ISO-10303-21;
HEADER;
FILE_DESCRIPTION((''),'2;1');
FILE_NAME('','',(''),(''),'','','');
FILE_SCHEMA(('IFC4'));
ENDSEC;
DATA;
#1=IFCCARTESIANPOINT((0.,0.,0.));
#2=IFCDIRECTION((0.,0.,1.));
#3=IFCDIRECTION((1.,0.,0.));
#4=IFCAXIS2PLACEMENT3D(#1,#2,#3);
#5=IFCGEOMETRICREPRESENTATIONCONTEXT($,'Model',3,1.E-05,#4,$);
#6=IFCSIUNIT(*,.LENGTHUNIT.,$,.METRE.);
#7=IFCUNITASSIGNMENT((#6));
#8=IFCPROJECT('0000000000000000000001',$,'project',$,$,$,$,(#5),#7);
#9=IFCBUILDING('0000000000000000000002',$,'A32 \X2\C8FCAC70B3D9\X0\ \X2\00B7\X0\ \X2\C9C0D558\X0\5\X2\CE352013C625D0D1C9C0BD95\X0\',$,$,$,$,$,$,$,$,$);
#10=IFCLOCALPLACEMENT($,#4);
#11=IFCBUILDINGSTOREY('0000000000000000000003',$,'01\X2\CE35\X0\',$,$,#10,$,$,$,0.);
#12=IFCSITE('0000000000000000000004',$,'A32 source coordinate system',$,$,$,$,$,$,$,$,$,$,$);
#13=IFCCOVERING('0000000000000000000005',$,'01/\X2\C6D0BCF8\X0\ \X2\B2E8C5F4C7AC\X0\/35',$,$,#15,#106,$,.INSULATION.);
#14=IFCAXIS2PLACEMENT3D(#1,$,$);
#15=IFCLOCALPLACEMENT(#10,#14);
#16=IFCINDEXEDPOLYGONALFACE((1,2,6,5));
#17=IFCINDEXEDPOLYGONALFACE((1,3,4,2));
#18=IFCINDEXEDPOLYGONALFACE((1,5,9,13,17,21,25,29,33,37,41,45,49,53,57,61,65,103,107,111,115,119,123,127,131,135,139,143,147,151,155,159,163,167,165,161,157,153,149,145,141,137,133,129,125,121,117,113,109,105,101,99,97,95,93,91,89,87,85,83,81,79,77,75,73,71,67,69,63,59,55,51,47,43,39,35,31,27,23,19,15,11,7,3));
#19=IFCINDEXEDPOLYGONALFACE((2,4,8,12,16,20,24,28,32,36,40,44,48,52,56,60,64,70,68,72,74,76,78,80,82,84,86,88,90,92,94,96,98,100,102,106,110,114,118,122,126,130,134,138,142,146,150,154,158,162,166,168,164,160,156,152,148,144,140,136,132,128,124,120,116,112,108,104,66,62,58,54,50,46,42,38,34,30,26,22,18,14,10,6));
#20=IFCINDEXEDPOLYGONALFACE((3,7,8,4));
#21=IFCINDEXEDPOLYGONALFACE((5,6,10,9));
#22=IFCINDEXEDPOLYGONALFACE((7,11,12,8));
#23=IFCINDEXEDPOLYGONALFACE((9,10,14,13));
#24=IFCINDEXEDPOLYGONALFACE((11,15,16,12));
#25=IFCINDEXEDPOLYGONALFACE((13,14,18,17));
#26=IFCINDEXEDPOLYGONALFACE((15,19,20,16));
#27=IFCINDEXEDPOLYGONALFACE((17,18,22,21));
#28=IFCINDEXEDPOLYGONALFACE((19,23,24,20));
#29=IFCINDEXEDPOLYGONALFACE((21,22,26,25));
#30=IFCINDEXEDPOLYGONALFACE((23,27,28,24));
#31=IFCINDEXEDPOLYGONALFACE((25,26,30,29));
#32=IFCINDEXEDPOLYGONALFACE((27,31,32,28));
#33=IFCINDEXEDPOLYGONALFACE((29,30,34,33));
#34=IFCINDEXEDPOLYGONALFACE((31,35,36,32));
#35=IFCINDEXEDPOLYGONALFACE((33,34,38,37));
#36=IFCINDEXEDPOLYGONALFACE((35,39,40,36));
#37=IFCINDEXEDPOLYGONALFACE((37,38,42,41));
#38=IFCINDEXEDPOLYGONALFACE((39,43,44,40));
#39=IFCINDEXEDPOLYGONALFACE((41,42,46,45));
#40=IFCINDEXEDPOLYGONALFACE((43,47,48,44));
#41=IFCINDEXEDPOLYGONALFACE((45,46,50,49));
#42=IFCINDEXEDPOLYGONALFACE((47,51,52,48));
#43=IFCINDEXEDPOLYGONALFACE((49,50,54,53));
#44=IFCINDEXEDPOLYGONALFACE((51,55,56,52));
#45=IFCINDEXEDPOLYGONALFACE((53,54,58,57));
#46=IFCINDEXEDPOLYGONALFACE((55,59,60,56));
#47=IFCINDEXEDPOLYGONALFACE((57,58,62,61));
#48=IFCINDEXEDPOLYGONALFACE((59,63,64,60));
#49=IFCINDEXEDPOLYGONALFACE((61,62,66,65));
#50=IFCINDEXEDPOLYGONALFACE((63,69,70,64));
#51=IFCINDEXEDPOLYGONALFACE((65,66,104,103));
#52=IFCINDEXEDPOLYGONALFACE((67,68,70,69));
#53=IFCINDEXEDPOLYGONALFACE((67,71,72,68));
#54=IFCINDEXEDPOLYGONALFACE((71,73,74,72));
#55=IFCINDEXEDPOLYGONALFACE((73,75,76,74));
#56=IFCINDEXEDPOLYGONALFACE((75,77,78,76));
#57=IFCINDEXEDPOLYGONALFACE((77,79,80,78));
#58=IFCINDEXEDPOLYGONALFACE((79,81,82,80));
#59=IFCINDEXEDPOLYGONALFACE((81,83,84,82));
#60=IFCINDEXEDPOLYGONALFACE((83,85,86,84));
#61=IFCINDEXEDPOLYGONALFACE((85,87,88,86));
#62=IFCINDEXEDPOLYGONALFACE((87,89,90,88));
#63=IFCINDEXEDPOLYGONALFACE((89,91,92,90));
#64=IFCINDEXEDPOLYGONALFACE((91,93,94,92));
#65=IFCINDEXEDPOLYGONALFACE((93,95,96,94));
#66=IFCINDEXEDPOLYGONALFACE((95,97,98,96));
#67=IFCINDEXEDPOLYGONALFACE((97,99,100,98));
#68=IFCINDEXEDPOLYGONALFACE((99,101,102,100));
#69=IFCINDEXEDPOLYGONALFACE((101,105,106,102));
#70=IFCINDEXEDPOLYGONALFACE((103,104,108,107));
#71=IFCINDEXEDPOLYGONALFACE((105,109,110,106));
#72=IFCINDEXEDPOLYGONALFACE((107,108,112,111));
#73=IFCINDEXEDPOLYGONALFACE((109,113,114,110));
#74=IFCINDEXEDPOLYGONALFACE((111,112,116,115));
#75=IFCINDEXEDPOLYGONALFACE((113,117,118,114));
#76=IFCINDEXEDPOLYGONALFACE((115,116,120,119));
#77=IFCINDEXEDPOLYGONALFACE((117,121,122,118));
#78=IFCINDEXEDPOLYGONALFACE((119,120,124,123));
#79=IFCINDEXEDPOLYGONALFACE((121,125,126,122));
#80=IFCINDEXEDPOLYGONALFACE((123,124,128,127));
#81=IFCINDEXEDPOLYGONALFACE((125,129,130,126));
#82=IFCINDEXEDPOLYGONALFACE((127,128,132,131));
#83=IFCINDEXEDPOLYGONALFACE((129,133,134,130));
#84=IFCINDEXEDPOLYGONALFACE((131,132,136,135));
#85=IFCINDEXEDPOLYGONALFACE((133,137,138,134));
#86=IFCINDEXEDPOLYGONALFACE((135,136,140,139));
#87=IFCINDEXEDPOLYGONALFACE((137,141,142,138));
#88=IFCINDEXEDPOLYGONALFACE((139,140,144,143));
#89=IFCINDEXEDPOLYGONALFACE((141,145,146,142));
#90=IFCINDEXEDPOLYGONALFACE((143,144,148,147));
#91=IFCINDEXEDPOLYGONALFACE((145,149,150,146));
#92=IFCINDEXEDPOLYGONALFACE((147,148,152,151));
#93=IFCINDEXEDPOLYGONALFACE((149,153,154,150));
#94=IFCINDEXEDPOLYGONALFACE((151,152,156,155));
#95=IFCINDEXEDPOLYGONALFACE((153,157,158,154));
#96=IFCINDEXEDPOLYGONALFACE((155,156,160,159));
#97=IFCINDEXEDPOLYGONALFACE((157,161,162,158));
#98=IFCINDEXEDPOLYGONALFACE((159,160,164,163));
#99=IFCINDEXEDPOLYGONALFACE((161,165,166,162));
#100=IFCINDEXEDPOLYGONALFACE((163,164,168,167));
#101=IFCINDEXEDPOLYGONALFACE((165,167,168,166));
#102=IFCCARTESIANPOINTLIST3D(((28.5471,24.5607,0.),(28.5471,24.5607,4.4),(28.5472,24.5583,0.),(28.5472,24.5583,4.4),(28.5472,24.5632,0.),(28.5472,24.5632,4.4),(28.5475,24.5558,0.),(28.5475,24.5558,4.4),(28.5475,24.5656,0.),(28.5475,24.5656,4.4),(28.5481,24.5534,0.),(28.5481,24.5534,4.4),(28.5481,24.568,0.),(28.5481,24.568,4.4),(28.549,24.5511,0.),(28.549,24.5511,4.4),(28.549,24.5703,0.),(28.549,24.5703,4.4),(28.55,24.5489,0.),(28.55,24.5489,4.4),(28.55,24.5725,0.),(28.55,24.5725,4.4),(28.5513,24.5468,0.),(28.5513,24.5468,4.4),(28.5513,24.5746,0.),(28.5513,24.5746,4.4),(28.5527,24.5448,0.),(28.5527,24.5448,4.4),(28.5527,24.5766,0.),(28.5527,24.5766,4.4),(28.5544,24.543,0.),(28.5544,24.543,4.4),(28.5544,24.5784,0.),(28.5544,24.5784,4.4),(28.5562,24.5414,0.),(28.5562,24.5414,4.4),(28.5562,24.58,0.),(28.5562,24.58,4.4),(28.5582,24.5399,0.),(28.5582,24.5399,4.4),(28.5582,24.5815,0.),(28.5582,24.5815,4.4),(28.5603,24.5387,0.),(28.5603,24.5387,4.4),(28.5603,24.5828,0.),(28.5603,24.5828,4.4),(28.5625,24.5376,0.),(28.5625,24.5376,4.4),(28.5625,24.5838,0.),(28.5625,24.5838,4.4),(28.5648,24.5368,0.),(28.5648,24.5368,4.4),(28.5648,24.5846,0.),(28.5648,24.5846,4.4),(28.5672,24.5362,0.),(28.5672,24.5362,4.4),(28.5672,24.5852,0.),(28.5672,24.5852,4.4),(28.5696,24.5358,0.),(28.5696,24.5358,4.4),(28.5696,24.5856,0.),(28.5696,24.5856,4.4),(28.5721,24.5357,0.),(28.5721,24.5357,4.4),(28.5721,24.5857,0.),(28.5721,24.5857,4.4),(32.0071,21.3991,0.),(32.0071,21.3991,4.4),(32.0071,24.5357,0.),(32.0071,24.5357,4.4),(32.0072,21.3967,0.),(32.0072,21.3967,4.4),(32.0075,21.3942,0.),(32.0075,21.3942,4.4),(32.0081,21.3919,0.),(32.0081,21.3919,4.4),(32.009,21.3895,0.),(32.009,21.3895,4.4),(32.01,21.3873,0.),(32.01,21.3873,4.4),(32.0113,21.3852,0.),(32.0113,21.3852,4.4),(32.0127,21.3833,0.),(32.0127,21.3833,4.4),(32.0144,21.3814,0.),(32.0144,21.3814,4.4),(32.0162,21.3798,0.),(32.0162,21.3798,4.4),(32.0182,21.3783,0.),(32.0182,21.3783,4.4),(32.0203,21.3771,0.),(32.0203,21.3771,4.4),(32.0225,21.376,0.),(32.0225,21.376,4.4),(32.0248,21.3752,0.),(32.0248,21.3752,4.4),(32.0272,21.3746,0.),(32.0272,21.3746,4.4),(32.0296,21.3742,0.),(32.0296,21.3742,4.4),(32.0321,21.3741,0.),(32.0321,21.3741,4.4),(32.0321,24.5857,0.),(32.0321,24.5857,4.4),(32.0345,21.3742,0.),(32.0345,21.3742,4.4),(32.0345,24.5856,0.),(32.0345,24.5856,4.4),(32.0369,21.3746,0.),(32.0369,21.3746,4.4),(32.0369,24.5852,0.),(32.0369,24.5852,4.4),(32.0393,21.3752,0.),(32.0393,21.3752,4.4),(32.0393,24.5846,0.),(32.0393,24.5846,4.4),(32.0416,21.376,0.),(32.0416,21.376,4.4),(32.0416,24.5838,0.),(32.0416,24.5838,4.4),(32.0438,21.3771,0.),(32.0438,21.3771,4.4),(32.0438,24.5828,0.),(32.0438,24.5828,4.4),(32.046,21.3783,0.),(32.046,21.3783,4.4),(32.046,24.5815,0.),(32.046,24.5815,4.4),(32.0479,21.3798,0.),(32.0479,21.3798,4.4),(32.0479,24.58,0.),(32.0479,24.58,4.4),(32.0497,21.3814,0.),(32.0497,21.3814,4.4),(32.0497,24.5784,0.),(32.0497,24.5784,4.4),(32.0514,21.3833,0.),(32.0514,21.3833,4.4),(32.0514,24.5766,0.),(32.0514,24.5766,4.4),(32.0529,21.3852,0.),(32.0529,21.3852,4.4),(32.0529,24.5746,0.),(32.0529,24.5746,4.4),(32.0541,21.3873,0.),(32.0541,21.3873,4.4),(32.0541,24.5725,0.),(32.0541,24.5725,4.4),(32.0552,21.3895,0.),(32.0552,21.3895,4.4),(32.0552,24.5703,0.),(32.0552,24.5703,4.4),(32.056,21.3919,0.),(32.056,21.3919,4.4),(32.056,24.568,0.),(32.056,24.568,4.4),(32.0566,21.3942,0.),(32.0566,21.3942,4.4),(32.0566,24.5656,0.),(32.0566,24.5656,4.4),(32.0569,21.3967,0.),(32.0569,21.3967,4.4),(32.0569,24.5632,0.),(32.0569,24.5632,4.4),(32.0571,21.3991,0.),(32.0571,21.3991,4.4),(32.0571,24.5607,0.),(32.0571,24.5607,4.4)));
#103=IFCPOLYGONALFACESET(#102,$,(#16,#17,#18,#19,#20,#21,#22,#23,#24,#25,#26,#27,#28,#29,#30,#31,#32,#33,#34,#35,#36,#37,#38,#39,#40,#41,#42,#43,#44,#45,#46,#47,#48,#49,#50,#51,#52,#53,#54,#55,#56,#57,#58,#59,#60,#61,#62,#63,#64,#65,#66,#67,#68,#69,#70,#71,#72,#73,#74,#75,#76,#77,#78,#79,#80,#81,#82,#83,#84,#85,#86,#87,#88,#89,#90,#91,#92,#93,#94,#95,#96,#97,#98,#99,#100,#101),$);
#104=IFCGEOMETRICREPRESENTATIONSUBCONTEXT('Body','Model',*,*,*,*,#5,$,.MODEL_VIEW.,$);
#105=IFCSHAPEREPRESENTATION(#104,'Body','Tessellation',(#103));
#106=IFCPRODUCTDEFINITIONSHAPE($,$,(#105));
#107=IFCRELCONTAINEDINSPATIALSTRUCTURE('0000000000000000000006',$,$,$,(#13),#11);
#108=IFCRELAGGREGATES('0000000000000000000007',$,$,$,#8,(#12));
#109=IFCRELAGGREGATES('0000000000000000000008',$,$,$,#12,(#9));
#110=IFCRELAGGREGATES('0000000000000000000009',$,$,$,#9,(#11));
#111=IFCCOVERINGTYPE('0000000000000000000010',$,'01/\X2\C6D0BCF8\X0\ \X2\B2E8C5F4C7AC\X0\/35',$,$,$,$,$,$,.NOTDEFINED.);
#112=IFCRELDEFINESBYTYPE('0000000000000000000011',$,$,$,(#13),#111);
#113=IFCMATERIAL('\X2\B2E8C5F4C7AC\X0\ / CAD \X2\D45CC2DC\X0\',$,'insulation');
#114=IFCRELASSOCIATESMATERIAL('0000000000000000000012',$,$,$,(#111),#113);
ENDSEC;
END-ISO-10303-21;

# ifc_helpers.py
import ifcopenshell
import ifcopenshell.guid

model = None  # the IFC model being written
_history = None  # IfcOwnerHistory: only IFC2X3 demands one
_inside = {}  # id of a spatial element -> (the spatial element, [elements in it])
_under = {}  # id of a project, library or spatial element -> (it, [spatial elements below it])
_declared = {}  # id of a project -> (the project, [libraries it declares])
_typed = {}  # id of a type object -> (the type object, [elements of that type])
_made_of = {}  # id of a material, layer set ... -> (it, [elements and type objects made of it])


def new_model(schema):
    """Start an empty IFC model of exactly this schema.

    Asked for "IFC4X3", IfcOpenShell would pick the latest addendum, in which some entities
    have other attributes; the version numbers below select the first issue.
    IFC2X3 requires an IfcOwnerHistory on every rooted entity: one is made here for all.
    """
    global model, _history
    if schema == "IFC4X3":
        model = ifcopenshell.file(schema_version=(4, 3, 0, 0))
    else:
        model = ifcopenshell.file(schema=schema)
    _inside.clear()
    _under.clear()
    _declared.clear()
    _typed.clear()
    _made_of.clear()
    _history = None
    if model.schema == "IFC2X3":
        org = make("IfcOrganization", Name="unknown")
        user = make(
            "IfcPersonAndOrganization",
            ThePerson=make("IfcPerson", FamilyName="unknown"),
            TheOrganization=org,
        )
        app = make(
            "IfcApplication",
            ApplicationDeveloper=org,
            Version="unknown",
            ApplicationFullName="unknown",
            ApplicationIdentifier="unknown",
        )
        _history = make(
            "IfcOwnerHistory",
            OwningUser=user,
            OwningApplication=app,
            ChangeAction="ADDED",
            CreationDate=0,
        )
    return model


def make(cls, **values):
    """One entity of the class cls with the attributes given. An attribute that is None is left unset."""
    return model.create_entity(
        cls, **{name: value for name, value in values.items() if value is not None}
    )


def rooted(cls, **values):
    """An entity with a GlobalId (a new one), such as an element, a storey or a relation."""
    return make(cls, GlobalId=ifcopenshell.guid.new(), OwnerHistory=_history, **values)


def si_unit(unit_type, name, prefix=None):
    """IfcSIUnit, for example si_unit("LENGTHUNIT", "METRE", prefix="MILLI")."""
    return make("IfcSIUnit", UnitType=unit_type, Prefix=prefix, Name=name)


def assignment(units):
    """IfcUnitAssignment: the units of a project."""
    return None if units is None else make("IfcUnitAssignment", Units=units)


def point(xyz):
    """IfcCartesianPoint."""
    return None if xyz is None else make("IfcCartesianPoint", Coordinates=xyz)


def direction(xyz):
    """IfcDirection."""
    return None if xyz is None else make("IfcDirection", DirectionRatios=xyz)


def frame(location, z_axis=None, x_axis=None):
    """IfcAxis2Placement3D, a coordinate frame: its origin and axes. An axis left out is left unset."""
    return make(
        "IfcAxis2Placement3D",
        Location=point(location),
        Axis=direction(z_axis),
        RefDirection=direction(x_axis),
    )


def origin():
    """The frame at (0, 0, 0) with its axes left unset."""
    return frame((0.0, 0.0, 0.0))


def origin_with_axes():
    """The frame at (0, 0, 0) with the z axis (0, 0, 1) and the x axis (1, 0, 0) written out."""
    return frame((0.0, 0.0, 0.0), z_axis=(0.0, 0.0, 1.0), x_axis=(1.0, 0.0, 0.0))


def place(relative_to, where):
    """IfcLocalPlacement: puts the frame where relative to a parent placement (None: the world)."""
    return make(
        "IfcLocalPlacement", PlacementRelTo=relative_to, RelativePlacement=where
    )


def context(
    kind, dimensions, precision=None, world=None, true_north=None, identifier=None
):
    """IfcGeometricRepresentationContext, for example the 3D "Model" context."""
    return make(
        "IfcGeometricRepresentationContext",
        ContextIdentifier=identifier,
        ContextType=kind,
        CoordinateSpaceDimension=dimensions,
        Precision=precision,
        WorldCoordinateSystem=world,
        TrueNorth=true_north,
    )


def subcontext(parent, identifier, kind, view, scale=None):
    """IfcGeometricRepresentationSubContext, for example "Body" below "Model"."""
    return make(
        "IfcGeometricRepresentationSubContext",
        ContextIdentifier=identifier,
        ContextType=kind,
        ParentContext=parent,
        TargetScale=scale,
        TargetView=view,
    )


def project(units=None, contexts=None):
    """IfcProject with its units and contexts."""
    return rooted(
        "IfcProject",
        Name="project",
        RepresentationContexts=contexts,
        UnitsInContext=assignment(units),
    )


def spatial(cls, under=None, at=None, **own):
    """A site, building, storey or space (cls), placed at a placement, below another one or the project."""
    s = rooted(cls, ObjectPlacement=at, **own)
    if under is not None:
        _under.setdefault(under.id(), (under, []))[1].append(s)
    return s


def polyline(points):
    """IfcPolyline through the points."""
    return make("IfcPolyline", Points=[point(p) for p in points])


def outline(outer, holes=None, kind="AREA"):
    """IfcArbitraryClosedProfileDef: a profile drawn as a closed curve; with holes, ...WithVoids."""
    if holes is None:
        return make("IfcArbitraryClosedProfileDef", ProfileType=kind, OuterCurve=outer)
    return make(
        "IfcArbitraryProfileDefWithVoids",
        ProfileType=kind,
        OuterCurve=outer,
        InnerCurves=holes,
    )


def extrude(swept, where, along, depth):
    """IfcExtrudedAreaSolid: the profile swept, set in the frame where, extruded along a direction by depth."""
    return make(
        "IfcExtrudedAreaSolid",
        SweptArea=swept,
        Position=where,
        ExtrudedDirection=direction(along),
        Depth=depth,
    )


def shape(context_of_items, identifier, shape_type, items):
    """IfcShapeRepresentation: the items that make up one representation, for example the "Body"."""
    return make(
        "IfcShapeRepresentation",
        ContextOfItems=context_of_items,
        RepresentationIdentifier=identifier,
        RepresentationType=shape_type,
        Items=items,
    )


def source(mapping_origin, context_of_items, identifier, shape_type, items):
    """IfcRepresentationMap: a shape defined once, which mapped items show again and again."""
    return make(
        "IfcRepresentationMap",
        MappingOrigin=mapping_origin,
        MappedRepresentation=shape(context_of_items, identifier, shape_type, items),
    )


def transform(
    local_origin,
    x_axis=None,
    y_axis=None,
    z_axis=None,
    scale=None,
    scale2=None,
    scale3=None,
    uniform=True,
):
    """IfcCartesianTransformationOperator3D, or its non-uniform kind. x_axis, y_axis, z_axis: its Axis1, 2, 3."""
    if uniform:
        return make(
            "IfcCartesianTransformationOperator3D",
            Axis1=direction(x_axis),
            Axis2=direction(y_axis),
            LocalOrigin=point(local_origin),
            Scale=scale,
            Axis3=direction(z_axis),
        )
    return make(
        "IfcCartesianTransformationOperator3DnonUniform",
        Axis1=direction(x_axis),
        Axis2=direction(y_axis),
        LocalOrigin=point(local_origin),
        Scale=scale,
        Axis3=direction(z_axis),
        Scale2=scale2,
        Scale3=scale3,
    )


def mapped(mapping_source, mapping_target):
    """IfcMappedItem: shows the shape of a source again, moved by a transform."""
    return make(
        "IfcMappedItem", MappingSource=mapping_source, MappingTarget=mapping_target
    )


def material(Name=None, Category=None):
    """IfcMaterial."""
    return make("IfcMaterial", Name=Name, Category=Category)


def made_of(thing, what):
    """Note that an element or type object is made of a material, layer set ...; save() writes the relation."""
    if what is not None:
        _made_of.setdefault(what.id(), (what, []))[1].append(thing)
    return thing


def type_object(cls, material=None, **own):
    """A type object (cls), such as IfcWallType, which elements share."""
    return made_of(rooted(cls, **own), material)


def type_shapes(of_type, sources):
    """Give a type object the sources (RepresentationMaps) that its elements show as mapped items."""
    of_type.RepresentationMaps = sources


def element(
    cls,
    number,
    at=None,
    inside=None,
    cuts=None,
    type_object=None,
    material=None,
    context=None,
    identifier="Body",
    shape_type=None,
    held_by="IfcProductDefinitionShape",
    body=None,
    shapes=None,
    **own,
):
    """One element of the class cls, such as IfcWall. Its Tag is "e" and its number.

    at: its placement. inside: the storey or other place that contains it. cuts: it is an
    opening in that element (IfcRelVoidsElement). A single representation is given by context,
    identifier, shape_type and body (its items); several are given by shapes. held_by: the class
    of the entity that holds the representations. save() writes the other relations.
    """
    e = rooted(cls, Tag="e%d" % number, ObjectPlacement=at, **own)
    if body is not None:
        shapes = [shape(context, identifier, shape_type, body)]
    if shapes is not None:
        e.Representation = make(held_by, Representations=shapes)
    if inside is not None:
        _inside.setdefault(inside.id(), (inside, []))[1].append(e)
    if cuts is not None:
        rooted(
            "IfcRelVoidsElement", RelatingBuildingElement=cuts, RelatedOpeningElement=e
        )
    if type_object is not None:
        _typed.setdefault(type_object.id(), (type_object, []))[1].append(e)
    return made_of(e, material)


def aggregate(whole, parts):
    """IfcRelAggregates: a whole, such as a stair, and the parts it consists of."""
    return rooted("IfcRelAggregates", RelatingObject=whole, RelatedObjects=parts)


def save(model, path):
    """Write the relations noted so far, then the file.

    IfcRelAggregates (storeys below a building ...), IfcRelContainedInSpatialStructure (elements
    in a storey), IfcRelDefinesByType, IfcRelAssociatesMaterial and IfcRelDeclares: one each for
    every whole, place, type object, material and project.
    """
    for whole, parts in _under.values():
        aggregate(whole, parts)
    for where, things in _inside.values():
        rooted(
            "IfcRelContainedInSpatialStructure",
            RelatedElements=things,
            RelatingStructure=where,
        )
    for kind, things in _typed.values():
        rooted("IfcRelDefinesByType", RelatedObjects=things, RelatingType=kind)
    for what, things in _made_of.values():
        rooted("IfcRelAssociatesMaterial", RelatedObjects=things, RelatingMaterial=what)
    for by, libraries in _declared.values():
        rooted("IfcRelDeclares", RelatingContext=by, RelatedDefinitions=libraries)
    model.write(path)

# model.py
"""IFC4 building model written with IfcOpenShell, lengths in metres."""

from ifc_helpers import new_model, si_unit, origin, origin_with_axes, place, context, subcontext, project, spatial, polyline, outline, extrude, source, transform, mapped, material, type_object, type_shapes, element, save


model = new_model("IFC4")

# Units and contexts
model_context = context("Model", 3, precision=1e-05, world=origin_with_axes())
body_context = subcontext(model_context, "Body", "Model", "MODEL_VIEW")
ifc_project = project(units=[si_unit("LENGTHUNIT", "METRE")], contexts=[model_context])

# Site, building, storey
site = spatial("IfcSite", under=ifc_project, Name="A32 source coordinate system")
building = spatial("IfcBuilding", under=site, Name="A32 주거동 · 지하5층–옥탑지붕")
storey_placement = place(None, origin_with_axes())
storey = spatial("IfcBuildingStorey", under=building, at=storey_placement, Name="01층", Elevation=0.0)

# Covering
ifc_material = material(Name="단열재 / CAD 표시", Category="insulation")
covering_type_1 = type_object("IfcCoveringType", Name="01/원본 단열재/35", PredefinedType="NOTDEFINED", material=ifc_material)
shared_shape_1 = source(origin(), body_context, "Body", "SweptSolid", [
    extrude(outline(polyline([(28.5582, 24.5399), (28.5562, 24.5414), (28.5544, 24.543), (28.5527, 24.5448), (28.5513, 24.5468), (28.55, 24.5489), (28.549, 24.5511), (28.5481, 24.5534), (28.5475, 24.5558), (28.5472, 24.5583), (28.5471, 24.5607), (28.5472, 24.5632), (28.5475, 24.5656), (28.5481, 24.568), (28.549, 24.5703), (28.55, 24.5725), (28.5513, 24.5746), (28.5527, 24.5766), (28.5544, 24.5784), (28.5562, 24.58), (28.5582, 24.5815), (28.5603, 24.5828), (28.5625, 24.5838), (28.5648, 24.5846), (28.5672, 24.5852), (28.5696, 24.5856), (28.5721, 24.5857), (32.0321, 24.5857), (32.0345, 24.5856), (32.0369, 24.5852), (32.0393, 24.5846), (32.0416, 24.5838), (32.0438, 24.5828), (32.046, 24.5815), (32.0479, 24.58), (32.0497, 24.5784), (32.0514, 24.5766), (32.0529, 24.5746), (32.0541, 24.5725), (32.0552, 24.5703), (32.056, 24.568), (32.0566, 24.5656), (32.0569, 24.5632), (32.0571, 24.5607), (32.0571, 24.5607), (32.0571, 21.3991), (32.0569, 21.3967), (32.0566, 21.3942), (32.056, 21.3919), (32.0552, 21.3895), (32.0541, 21.3873), (32.0529, 21.3852), (32.0514, 21.3833), (32.0497, 21.3814), (32.0479, 21.3798), (32.046, 21.3783), (32.0438, 21.3771), (32.0416, 21.376), (32.0393, 21.3752), (32.0369, 21.3746), (32.0345, 21.3742), (32.0321, 21.3741), (32.0296, 21.3742), (32.0272, 21.3746), (32.0248, 21.3752), (32.0225, 21.376), (32.0203, 21.3771), (32.0182, 21.3783), (32.0162, 21.3798), (32.0144, 21.3814), (32.0127, 21.3833), (32.0113, 21.3852), (32.01, 21.3873), (32.009, 21.3895), (32.0081, 21.3919), (32.0075, 21.3942), (32.0072, 21.3967), (32.0071, 21.3991), (32.0071, 24.5357), (28.5721, 24.5357), (28.5696, 24.5358), (28.5672, 24.5362), (28.5648, 24.5368), (28.5625, 24.5376), (28.5603, 24.5387), (28.5582, 24.5399)])), origin(), (0.0, 0.0, 1.0), 4.4),
])
type_shapes(covering_type_1, [shared_shape_1])
covering_1_placement = place(storey_placement, origin_with_axes())
element("IfcCovering", 1, at=covering_1_placement, inside=storey, type_object=covering_type_1, Name="01/원본 단열재/35", PredefinedType="INSULATION", context=body_context, shape_type="MappedRepresentation", body=[
    mapped(shared_shape_1, transform((0.0, 0.0, 0.0), scale=1.0)),
])

save(model, "model.ifc")
